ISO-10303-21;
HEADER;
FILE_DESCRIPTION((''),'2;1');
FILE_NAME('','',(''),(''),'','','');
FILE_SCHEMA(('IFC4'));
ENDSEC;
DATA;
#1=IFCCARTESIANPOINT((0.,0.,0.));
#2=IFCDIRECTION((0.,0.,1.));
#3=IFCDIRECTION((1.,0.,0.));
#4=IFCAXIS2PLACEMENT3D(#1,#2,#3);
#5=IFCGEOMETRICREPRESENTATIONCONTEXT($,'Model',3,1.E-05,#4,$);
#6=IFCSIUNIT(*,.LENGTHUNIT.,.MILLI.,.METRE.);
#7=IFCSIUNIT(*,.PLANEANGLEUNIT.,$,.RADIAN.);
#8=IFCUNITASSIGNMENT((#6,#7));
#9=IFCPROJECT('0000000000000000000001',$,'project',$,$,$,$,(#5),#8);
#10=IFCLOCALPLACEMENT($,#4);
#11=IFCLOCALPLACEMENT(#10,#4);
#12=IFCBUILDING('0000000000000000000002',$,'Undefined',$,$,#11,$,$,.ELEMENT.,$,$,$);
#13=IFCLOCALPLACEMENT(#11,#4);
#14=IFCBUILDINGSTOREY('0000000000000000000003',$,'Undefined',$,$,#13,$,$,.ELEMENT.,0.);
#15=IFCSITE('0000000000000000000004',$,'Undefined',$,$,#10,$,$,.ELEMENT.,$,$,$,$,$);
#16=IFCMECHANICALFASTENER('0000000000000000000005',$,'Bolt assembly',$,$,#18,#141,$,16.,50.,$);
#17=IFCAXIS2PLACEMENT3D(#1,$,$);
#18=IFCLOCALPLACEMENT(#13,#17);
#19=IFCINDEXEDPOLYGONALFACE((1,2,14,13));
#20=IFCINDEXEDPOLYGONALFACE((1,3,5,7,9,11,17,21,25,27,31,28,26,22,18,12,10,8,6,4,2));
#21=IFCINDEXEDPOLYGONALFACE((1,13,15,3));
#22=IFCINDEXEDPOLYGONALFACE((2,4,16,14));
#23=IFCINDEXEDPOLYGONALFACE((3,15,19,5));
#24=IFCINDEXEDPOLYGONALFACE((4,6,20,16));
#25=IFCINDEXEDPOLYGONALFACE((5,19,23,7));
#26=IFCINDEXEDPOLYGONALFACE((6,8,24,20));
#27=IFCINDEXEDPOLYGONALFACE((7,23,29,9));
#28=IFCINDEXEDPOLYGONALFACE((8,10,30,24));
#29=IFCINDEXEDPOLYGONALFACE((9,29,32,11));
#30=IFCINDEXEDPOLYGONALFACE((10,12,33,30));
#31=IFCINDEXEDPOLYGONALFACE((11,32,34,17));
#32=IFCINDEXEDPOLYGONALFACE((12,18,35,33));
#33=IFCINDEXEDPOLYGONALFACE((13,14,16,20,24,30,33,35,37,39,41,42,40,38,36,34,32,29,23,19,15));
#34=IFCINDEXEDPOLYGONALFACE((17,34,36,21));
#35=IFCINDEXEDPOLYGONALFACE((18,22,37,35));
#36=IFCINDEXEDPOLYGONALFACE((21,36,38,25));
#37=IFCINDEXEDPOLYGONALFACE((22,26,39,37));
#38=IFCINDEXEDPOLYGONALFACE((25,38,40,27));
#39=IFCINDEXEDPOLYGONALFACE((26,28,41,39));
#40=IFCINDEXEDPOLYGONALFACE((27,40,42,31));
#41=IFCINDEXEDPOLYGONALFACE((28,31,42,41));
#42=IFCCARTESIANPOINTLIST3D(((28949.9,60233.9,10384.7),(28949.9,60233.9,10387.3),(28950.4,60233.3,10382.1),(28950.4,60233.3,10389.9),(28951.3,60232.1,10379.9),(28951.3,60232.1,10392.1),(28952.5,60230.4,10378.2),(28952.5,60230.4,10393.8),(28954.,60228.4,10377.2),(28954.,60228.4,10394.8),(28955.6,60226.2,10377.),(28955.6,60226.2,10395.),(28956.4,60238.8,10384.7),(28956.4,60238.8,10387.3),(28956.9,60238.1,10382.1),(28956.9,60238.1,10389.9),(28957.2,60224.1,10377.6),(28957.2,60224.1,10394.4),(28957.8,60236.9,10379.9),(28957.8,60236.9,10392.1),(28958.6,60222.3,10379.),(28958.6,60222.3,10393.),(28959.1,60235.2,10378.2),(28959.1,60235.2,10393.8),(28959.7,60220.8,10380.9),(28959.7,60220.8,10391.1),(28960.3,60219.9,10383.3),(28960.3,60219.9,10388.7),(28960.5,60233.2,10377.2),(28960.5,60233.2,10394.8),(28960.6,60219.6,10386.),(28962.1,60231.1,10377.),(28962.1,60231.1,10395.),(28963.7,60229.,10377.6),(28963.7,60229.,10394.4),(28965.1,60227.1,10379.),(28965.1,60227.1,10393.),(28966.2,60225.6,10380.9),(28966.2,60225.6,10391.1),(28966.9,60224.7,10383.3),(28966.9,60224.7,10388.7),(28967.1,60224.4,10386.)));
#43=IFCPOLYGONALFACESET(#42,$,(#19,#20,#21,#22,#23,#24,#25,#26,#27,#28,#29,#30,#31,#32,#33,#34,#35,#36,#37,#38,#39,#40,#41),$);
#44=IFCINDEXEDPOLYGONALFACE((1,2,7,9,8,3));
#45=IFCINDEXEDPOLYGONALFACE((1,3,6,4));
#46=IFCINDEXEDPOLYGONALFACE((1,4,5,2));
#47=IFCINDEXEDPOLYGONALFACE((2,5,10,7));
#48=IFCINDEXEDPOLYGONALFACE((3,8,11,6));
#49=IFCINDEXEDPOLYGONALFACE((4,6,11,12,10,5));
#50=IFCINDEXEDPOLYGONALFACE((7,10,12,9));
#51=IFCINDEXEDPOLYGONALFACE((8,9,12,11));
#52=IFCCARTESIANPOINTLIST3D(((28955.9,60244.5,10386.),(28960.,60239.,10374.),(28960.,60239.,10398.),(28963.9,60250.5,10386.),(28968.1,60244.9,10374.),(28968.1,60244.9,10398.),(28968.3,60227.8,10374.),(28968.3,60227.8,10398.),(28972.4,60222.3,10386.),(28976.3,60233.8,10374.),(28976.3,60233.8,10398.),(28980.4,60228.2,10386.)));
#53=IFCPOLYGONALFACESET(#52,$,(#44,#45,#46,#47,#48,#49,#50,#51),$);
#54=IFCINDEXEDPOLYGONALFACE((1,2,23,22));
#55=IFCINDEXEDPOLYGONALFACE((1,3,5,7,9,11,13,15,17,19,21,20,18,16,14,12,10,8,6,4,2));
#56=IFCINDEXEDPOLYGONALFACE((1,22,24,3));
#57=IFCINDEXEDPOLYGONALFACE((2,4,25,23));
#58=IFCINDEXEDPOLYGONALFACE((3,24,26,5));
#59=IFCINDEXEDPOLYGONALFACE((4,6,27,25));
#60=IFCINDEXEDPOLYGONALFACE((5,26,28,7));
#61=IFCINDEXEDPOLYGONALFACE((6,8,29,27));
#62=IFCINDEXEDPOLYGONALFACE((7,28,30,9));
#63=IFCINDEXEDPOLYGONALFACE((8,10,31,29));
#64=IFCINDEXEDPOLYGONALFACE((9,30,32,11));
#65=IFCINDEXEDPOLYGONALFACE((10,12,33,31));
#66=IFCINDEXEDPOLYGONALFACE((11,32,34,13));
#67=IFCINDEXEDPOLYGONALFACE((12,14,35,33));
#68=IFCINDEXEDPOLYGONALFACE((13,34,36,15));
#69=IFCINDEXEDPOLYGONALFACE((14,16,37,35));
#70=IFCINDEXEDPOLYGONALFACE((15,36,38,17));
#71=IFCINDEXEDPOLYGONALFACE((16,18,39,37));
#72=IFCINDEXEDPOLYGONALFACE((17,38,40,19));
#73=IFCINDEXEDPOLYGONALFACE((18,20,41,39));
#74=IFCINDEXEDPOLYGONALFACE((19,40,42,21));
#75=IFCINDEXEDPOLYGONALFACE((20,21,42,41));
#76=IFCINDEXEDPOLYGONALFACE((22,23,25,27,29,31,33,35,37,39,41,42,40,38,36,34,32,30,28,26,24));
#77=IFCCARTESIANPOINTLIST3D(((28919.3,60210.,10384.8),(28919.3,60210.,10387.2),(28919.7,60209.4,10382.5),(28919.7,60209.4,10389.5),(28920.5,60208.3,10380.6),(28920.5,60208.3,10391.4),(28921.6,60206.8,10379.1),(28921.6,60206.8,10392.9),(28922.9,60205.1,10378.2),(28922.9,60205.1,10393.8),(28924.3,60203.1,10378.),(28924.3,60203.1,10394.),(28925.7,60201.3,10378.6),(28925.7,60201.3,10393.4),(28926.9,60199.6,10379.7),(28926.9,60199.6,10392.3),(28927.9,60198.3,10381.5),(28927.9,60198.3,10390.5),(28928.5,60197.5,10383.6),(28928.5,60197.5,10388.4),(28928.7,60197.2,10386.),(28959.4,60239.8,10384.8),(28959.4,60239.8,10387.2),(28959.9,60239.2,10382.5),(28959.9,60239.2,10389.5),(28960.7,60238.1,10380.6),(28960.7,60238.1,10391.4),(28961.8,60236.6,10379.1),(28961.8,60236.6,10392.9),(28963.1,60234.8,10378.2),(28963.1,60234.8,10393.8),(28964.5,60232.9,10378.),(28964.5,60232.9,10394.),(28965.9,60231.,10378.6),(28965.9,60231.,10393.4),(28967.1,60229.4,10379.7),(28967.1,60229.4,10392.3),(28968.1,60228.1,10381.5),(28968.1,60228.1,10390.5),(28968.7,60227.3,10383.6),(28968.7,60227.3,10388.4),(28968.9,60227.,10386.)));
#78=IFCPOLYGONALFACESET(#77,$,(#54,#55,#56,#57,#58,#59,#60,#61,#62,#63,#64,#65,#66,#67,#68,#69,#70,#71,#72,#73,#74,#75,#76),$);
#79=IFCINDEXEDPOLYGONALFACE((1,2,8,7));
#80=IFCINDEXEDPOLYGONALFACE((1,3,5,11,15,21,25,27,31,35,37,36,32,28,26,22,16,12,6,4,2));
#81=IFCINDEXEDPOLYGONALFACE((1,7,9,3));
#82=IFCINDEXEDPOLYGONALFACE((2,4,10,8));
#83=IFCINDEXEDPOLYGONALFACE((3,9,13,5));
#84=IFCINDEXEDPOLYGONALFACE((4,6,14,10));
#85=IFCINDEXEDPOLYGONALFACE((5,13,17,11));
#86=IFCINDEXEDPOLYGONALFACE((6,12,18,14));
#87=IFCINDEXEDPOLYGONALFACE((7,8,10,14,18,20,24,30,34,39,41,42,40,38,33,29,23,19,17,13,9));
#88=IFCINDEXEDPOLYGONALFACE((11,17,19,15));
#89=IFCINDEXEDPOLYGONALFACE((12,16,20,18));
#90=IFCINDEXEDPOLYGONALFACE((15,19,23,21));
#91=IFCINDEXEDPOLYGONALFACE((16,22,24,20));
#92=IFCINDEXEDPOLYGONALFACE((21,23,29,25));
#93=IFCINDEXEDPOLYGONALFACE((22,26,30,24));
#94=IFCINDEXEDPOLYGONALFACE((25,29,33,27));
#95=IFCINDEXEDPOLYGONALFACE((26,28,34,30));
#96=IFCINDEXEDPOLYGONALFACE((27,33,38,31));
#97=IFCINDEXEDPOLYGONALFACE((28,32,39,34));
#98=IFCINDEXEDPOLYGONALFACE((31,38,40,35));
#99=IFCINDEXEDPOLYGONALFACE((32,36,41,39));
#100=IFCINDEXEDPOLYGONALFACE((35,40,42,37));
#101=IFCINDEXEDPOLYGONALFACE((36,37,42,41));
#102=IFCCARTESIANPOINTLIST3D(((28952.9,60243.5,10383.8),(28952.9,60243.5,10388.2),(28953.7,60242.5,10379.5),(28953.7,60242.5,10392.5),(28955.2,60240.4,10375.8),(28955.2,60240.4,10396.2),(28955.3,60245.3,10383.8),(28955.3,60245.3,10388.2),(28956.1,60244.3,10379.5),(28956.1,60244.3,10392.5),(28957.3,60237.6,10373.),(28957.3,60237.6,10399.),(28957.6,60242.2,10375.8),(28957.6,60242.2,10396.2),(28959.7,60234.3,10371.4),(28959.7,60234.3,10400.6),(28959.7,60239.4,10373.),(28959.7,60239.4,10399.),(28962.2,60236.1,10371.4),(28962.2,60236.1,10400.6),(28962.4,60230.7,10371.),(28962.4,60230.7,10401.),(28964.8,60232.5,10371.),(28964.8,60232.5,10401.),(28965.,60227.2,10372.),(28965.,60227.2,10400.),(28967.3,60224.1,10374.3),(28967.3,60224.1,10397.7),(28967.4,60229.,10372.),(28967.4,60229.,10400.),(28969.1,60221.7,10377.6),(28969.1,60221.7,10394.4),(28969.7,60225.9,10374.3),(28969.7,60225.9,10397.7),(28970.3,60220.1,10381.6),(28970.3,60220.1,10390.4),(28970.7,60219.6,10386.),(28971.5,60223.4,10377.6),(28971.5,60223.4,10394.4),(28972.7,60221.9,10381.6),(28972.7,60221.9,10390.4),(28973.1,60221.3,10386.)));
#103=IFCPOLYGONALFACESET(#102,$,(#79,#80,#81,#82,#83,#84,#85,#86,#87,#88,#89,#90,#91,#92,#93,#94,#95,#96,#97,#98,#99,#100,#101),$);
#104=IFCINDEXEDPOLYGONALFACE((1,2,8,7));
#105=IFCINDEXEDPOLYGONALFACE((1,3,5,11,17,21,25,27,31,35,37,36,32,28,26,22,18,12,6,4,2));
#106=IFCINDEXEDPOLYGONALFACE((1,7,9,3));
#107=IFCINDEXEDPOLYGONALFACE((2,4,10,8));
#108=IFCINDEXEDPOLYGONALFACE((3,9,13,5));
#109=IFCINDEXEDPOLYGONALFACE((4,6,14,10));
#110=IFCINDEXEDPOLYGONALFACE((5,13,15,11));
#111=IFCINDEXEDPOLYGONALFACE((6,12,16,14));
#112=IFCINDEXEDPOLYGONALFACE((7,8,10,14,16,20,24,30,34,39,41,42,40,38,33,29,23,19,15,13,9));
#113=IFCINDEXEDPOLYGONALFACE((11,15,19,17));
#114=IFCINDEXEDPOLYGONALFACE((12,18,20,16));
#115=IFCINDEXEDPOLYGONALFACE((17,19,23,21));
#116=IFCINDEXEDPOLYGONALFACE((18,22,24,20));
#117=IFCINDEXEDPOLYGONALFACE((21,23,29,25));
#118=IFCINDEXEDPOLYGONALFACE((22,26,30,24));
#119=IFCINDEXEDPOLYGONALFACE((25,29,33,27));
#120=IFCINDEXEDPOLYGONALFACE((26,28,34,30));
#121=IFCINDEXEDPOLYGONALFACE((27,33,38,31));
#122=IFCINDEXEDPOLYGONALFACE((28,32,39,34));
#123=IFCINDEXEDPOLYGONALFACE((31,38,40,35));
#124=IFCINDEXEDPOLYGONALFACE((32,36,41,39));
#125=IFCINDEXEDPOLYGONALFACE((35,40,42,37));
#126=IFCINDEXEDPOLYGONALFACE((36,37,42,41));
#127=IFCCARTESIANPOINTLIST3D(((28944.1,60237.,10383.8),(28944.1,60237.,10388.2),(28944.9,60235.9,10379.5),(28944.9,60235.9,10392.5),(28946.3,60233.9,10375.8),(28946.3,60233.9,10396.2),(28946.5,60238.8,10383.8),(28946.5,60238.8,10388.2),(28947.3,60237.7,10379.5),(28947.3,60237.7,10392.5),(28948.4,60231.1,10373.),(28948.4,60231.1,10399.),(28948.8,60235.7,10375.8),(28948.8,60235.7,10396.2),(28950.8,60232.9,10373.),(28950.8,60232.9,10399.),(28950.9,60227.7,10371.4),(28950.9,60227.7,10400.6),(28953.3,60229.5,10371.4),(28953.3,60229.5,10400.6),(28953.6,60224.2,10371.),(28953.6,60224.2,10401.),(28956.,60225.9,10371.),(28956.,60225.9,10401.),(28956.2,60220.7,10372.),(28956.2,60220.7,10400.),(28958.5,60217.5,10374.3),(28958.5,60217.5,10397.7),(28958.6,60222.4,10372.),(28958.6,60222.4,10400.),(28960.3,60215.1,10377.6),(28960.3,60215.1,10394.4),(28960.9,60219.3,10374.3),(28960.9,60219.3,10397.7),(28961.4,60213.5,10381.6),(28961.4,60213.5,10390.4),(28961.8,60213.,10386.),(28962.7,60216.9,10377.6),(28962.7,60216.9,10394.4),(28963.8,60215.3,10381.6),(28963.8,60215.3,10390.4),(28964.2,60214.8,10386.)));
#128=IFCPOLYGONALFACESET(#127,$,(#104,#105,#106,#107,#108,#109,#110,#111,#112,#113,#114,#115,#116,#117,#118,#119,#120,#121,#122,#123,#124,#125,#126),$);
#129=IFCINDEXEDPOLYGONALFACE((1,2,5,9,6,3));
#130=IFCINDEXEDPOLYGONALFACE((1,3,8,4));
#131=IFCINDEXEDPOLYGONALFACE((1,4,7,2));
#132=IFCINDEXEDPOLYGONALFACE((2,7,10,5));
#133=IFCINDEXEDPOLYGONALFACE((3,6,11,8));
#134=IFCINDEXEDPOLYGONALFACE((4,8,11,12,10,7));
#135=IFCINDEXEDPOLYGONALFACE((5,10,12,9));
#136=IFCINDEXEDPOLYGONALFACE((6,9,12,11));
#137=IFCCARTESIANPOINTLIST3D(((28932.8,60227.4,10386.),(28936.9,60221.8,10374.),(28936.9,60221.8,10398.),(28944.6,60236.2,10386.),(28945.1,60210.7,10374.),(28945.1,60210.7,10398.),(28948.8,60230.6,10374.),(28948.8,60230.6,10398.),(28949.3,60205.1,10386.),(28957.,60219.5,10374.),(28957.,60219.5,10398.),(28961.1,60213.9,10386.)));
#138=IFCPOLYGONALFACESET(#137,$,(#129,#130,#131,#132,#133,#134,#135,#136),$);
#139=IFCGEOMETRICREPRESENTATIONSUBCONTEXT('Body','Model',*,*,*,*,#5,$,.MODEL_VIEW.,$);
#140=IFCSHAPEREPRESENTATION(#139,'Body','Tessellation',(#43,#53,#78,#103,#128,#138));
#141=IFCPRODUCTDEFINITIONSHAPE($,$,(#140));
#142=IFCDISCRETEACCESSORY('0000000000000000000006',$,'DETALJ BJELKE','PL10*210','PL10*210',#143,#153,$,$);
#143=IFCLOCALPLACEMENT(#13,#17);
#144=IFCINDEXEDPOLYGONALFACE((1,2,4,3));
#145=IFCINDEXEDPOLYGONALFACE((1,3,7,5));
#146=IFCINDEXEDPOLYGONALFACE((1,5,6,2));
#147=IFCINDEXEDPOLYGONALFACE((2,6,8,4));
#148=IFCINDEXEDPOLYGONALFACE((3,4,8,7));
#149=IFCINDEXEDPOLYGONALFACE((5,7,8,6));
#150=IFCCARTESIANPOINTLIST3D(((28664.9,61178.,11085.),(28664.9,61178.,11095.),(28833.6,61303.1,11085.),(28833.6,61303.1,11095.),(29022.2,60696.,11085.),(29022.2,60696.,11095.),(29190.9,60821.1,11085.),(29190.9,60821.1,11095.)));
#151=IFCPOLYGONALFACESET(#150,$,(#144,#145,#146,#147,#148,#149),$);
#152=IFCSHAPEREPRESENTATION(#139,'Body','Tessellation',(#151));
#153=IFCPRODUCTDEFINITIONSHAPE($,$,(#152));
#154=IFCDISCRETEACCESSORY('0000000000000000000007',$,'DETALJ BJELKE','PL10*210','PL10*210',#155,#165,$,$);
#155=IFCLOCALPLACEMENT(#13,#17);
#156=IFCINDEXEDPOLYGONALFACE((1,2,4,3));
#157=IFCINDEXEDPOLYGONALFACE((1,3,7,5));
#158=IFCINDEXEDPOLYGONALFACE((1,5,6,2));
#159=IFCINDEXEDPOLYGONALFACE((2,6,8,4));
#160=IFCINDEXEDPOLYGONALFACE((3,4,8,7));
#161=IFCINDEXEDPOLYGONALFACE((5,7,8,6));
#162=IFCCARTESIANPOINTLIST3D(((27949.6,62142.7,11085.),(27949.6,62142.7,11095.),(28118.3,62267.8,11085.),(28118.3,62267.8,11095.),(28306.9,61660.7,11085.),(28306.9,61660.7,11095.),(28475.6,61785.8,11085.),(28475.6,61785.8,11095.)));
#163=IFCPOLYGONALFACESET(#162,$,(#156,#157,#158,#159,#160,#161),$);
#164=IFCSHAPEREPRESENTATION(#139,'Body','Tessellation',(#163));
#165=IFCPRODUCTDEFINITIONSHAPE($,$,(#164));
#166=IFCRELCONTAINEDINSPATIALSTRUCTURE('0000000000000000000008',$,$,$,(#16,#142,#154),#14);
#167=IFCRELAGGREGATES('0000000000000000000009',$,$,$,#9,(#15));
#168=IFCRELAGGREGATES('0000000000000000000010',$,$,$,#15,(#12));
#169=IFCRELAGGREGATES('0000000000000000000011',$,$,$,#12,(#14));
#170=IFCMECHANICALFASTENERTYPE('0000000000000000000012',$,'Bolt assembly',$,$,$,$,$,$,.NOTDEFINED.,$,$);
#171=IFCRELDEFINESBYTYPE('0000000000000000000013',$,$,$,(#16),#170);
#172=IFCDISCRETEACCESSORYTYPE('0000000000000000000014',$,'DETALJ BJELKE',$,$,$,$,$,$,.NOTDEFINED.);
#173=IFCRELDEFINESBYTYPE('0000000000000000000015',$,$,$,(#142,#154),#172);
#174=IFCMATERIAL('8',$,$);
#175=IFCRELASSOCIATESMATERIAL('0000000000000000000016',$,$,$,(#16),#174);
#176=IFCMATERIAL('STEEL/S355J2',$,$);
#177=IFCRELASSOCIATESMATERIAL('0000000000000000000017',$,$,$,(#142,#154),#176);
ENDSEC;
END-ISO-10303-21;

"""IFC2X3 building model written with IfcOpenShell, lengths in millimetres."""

from ifc_helpers import new_model, si_unit, frame, origin_with_axes, origin_2d_with_axis, place, context, subcontext, project, spatial, polyline, circle, outline, extrude, source, transform, mapped, material, type_object, element, save


model = new_model("IFC2X3")

# Units and contexts
model_context = context("Model", 3, precision=1e-05, world=origin_with_axes())
body_context = subcontext(model_context, "Body", "Model", "MODEL_VIEW")
ifc_project = project(units=[si_unit("LENGTHUNIT", "METRE", prefix="MILLI"), si_unit("PLANEANGLEUNIT", "RADIAN")], contexts=[model_context])

# Site, building, storey
site_placement = place(None, origin_with_axes())
site = spatial("IfcSite", under=ifc_project, at=site_placement, Name="Undefined", CompositionType="ELEMENT")
building_placement = place(site_placement, origin_with_axes())
building = spatial("IfcBuilding", under=site, at=building_placement, Name="Undefined", CompositionType="ELEMENT")
storey_placement = place(building_placement, origin_with_axes())
storey = spatial("IfcBuildingStorey", under=building, at=storey_placement, Name="Undefined", CompositionType="ELEMENT", Elevation=0.0)

# Shared definitions
ifc_material_1 = material(Name="STEEL/S355J2")

# Mechanical fastener
ifc_material_2 = material(Name="8")
mechanical_fastener_type = type_object("IfcMechanicalFastenerType", Name="Bolt assembly")
shared_shape_1 = source(origin_with_axes(), body_context, "Body", "SweptSolid", [
    extrude(circle(Radius=9.0, at=origin_2d_with_axis()), frame((0.0, 0.0, 0.0), z_axis=(0.0, 1.0, 0.0), x_axis=(1.0, 0.0, 0.0)), (0.0, 0.0, 1.0), 8.1),
    extrude(outline(polyline([(13.9, 0.0), (6.9, 12.0), (-6.9, 12.0), (-13.9, 0.0), (-6.9, -12.0), (6.9, -12.0), (13.9, 0.0)])), frame((0.0, -13.0, 0.0), z_axis=(0.0, 1.0, 0.0), x_axis=(1.0, 0.0, 0.0)), (0.0, 0.0, 1.0), 10.0),
    extrude(circle(Radius=8.0, at=origin_2d_with_axis()), frame((0.0, -3.0, 0.0), z_axis=(0.0, 1.0, 0.0), x_axis=(1.0, 0.0, 0.0)), (0.0, 0.0, 1.0), 50.0),
    extrude(circle(Radius=15.0, at=origin_2d_with_axis()), frame((0.0, -3.0, 0.0), z_axis=(0.0, 1.0, 0.0), x_axis=(1.0, 0.0, 0.0)), (0.0, 0.0, 1.0), 3.0),
    extrude(circle(Radius=15.0, at=origin_2d_with_axis()), frame((0.0, 8.0, 0.0), z_axis=(0.0, 1.0, 0.0), x_axis=(1.0, 0.0, 0.0)), (0.0, 0.0, 1.0), 3.0),
    extrude(outline(polyline([(13.9, 0.0), (6.9, 12.0), (-6.9, 12.0), (-13.9, 0.0), (-6.9, -12.0), (6.9, -12.0), (13.9, 0.0)])), frame((0.0, 11.0, 0.0), z_axis=(0.0, 1.0, 0.0), x_axis=(1.0, 0.0, 0.0)), (0.0, 0.0, 1.0), 14.8),
])
mechanical_fastener_1_placement = place(storey_placement, frame((28961.7, 60231.6, 10386.0), z_axis=(0.0, 0.0, -1.0), x_axis=(0.595445, -0.803396, 0.0)))
element("IfcMechanicalFastener", 1, at=mechanical_fastener_1_placement, inside=storey, type_object=mechanical_fastener_type, material=ifc_material_2, Name="Bolt assembly", NominalDiameter=16.0, NominalLength=50.0, context=body_context, shape_type="MappedRepresentation", body=[
    mapped(shared_shape_1, transform((0.0, 0.0, 0.0))),
])

# Discrete accessories
discrete_accessory_type_1 = type_object("IfcDiscreteAccessoryType", Name="DETALJ BJELKE")
for number, where, z_axis, x_axis, name in (
    (2, (29106.6, 60758.5, 11090.0), (0.0, 0.0, 1.0), (-0.595514, 0.803345, 0.0), "DETALJ BJELKE"),
    (3, (28391.3, 61723.3, 11090.0), (0.0, 0.0, 1.0), (-0.595514, 0.803345, 0.0), "DETALJ BJELKE"),
):
    element("IfcDiscreteAccessory", number, at=place(storey_placement, frame(where, z_axis=z_axis, x_axis=x_axis)), inside=storey, type_object=discrete_accessory_type_1, material=ifc_material_1, Name=name, Description="PL10*210", ObjectType="PL10*210", context=body_context, shape_type="SweptSolid", body=[
        extrude(outline(polyline([(600.0, 105.0), (600.0, -105.0), (0.0, -105.0), (0.0, 105.0), (600.0, 105.0)])), frame((0.0, 0.0, -5.0), z_axis=(0.0, 0.0, 1.0), x_axis=(1.0, 0.0, 0.0)), (0.0, 0.0, 1.0), 10.0),
    ])

save(model, "model.ifc")
